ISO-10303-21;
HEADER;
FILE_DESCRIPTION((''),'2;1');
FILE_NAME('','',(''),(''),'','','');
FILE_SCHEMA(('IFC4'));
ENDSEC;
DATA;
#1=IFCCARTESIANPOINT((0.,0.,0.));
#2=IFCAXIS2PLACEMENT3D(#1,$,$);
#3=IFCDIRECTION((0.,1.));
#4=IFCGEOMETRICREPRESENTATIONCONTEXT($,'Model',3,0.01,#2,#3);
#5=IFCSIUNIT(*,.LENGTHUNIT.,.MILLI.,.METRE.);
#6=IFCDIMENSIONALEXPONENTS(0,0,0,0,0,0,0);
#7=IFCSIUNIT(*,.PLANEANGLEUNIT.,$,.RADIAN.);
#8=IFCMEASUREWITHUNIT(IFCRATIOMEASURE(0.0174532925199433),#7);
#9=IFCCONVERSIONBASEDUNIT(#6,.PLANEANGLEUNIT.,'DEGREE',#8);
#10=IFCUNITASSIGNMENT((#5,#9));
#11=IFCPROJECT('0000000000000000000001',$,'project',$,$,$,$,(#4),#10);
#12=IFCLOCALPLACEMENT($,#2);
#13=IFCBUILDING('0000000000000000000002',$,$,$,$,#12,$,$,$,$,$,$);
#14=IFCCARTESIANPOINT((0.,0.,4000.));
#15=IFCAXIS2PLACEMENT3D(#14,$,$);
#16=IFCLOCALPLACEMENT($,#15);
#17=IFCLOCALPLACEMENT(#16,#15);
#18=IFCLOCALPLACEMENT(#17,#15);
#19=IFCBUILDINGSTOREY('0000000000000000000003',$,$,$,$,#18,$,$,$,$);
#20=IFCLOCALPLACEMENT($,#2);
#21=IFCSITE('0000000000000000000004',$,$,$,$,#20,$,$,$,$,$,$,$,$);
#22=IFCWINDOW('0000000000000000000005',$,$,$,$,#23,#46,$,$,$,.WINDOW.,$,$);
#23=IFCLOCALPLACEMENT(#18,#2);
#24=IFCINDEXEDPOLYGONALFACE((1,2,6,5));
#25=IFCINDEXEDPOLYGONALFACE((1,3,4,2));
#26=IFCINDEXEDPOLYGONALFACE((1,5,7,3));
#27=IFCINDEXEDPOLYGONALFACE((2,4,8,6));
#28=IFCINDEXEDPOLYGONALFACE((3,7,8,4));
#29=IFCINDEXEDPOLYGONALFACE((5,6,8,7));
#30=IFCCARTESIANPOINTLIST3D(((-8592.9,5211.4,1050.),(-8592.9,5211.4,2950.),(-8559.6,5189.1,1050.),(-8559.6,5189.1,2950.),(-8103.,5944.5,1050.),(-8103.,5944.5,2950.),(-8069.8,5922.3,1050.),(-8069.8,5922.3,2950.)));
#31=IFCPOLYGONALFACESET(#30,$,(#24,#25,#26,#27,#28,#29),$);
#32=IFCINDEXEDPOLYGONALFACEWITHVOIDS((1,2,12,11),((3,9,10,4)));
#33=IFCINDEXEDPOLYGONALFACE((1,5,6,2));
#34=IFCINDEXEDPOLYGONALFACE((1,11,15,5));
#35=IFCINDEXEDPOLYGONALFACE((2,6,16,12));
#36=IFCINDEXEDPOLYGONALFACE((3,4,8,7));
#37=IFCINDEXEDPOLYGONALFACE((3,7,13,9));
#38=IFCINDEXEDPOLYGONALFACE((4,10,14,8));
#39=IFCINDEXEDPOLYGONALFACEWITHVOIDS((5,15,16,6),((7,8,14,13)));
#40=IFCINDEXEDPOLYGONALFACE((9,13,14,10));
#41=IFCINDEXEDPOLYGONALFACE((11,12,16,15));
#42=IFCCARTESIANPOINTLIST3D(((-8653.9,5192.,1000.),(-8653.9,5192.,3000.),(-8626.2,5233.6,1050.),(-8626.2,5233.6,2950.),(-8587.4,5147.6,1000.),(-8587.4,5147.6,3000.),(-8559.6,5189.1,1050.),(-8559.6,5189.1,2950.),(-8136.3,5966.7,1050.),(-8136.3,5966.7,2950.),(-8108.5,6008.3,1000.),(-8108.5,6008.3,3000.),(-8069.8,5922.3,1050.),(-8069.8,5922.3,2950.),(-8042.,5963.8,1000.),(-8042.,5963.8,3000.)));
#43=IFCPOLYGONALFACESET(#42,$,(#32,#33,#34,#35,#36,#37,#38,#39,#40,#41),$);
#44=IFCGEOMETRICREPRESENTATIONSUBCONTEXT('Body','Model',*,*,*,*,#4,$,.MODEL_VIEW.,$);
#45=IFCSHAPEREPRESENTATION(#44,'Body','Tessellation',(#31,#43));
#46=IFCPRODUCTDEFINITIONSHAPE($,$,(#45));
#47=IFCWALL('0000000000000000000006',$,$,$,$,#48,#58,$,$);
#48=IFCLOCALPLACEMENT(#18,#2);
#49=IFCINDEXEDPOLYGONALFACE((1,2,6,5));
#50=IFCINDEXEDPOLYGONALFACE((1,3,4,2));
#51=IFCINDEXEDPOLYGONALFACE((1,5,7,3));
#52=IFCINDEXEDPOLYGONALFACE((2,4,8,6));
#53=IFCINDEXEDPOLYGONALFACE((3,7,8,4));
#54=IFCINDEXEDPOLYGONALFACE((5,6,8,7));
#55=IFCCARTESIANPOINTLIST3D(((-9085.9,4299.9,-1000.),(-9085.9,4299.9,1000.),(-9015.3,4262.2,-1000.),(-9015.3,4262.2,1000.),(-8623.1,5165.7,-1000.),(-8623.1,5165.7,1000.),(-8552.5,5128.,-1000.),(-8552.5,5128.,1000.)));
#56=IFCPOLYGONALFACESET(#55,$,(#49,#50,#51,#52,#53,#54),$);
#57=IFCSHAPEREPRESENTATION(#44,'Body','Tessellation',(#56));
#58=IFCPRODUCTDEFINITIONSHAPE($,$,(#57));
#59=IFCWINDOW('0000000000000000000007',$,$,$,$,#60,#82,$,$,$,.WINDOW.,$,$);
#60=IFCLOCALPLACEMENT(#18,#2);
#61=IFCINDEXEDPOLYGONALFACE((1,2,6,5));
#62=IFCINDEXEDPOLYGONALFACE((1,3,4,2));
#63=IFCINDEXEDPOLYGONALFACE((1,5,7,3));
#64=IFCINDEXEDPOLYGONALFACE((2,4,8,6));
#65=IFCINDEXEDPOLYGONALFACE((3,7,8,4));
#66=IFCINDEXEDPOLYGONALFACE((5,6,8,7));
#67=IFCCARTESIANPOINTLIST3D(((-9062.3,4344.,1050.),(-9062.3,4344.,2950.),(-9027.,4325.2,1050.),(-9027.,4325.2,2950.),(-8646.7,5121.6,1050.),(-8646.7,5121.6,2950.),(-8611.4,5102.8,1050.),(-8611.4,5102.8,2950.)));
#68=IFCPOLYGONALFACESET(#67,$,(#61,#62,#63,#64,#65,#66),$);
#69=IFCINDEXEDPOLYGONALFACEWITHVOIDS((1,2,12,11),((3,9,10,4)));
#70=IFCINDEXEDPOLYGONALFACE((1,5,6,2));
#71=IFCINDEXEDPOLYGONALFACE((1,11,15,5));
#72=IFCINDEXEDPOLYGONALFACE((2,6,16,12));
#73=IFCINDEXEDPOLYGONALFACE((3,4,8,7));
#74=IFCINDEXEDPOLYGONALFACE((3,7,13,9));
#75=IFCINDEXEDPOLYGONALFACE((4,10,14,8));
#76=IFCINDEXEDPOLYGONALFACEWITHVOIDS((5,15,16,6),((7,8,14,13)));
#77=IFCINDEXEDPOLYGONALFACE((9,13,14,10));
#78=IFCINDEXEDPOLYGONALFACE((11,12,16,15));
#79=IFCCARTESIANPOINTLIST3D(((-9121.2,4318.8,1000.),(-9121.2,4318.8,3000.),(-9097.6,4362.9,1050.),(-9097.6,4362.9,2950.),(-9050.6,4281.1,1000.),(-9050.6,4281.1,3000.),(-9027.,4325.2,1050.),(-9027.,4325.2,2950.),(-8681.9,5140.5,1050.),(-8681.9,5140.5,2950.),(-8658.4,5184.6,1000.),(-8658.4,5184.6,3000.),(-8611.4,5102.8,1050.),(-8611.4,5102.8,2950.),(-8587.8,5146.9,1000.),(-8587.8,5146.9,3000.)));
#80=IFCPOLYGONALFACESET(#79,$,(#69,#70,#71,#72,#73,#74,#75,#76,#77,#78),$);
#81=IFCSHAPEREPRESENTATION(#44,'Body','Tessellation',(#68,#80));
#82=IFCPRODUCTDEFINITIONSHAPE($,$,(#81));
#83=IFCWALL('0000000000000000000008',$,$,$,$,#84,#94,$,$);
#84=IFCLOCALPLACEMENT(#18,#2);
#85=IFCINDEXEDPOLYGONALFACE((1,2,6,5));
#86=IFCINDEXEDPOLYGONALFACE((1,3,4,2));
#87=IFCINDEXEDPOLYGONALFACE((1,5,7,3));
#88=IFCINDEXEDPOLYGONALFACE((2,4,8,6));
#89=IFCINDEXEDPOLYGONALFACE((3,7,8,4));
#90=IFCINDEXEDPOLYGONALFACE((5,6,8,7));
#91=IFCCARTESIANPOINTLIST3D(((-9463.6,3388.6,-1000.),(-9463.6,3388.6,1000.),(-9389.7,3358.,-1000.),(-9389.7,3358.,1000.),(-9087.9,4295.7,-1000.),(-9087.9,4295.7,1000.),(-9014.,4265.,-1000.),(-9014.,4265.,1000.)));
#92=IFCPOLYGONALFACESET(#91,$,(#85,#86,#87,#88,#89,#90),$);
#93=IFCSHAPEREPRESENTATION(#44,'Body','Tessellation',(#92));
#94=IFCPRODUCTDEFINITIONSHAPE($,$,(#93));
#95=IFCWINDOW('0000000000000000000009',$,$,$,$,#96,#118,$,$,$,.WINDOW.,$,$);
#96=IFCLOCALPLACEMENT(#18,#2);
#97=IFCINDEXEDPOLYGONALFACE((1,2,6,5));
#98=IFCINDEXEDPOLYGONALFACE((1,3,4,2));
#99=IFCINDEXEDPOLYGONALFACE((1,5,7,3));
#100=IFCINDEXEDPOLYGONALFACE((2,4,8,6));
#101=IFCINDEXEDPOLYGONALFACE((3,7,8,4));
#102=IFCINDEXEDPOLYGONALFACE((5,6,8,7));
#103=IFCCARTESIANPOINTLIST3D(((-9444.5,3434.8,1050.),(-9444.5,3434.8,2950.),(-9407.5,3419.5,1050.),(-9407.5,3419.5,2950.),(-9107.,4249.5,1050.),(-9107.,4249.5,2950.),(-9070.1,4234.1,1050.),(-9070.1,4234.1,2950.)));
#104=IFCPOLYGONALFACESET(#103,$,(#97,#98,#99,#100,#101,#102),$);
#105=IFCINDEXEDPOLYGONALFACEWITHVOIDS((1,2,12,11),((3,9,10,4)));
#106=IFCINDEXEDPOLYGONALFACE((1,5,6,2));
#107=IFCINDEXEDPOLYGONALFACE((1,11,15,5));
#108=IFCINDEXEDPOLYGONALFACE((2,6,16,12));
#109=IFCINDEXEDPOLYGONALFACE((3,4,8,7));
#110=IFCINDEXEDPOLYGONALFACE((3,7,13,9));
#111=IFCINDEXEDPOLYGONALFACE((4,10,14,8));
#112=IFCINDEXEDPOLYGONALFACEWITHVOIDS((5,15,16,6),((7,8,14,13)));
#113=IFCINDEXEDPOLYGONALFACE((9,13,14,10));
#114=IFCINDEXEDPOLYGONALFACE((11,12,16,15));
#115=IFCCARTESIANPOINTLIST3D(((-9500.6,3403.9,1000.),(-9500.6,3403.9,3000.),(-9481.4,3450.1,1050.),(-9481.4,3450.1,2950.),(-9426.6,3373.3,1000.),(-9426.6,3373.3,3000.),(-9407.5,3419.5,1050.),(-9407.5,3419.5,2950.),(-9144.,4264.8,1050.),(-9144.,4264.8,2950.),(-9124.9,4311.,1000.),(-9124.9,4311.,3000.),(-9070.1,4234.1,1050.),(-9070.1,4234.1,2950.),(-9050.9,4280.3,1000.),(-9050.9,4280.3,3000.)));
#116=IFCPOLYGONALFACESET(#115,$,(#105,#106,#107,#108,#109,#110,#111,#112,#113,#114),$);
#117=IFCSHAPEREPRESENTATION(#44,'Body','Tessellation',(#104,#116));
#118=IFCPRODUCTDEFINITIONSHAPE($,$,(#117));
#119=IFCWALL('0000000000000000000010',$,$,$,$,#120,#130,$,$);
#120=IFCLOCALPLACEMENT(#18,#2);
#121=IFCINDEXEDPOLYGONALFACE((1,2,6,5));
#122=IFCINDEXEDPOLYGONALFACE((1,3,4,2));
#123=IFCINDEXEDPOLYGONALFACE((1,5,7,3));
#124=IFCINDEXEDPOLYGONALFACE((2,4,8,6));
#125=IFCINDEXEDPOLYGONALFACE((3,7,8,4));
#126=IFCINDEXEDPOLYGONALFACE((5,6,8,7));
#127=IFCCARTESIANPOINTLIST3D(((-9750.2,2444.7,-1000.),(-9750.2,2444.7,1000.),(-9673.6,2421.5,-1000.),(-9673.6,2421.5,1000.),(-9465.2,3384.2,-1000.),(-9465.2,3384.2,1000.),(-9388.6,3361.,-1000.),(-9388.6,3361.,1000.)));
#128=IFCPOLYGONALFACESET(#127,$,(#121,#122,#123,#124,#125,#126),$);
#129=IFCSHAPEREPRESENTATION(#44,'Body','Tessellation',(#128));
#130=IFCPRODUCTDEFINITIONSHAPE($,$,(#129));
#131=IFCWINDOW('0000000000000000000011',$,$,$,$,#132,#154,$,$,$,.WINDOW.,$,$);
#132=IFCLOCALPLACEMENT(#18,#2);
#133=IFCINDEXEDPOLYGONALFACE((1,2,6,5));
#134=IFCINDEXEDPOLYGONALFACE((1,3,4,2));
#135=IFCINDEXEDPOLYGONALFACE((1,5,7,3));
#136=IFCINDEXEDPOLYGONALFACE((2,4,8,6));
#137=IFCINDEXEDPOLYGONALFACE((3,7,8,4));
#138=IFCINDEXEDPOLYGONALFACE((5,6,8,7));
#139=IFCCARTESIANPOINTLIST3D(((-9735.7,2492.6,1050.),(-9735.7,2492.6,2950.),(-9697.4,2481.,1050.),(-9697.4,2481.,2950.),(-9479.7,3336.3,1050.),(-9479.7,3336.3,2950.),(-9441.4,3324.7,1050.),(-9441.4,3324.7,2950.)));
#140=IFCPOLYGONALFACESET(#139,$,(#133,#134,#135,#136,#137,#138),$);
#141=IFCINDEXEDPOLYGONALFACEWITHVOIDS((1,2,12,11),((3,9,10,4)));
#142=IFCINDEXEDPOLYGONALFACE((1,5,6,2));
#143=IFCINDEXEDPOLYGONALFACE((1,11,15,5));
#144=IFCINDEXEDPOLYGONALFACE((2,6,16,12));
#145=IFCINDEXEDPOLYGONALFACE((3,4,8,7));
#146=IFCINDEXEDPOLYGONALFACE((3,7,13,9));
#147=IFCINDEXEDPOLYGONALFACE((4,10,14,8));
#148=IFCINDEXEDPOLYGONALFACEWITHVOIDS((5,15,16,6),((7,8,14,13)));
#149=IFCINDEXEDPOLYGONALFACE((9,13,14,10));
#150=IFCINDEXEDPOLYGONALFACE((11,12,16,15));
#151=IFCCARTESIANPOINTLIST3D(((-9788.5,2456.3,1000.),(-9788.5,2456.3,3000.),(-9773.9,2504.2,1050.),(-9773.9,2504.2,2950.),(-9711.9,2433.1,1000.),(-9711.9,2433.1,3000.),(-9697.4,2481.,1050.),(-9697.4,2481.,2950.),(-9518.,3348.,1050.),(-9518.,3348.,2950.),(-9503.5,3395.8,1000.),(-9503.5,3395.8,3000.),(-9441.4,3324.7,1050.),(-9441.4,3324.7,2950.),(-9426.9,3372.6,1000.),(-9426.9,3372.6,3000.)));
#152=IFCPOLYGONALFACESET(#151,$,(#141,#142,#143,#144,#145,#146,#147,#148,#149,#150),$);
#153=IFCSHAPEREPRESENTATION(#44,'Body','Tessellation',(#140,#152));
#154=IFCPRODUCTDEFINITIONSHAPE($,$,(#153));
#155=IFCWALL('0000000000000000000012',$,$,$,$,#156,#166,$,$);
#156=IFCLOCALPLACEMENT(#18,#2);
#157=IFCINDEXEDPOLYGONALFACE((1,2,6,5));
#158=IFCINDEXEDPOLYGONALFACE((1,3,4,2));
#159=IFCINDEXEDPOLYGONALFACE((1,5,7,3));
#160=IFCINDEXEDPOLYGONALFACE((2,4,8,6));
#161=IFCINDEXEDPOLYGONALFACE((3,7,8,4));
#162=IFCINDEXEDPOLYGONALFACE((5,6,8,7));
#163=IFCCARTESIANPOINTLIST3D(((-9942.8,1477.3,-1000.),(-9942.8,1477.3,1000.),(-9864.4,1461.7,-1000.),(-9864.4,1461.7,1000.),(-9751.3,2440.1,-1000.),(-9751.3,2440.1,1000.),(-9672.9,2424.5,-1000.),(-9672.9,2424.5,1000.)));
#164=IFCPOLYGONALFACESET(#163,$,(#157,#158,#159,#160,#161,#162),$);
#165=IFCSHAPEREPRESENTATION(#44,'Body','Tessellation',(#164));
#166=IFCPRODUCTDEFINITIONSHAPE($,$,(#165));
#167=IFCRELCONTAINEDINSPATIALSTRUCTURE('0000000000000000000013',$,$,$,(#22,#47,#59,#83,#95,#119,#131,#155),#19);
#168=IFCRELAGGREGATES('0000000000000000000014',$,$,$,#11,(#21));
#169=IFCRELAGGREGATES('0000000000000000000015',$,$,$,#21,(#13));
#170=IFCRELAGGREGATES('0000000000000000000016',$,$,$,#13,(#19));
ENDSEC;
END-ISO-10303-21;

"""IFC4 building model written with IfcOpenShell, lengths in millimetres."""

from ifc_helpers import new_model, entity, si_unit, converted_unit, direction, frame, origin, origin_2d, place, context, subcontext, project, spatial, rectangle, extrude, element, save


model = new_model("IFC4")

# Units and contexts
model_context = context("Model", 3, precision=0.01, world=origin(), true_north=direction((0.0, 1.0)))
body_context = subcontext(model_context, "Body", "Model", "MODEL_VIEW")
ifc_project = project(units=[si_unit("LENGTHUNIT", "METRE", prefix="MILLI"), converted_unit("PLANEANGLEUNIT", "DEGREE", entity("IfcRatioMeasure", 0.0174532925199433), si_unit("PLANEANGLEUNIT", "RADIAN"), dimensions=[0, 0, 0, 0, 0, 0, 0])], contexts=[model_context])

# Site, building, storey
site_placement = place(None, origin())
site = spatial("IfcSite", under=ifc_project, at=site_placement)
building_placement = place(None, origin())
building = spatial("IfcBuilding", under=site, at=building_placement)
placement_1 = place(None, frame((0.0, 0.0, 4000.0)))
placement_2 = place(placement_1, frame((0.0, 0.0, 4000.0)))
storey_placement = place(placement_2, frame((0.0, 0.0, 4000.0)))
storey = spatial("IfcBuildingStorey", under=building, at=storey_placement)

# Shared definitions
cartesian_point_1 = entity("IfcCartesianPoint", [-440.9, -950.0])
shared_polyline = entity("IfcPolyline", [cartesian_point_1, entity("IfcCartesianPoint", [-440.9, 950.0]), entity("IfcCartesianPoint", [-440.9, 950.0]), entity("IfcCartesianPoint", [440.9, 950.0]), entity("IfcCartesianPoint", [440.9, 950.0]), entity("IfcCartesianPoint", [440.9, -950.0]), entity("IfcCartesianPoint", [440.9, -950.0]), entity("IfcCartesianPoint", [-440.9, -950.0]), cartesian_point_1])

# Window
window_1_placement = place(storey_placement, frame((-8314.7, 5555.7, 2000.0), z_axis=(0.0, 0.0, 1.0), x_axis=(-5555.701616, -8314.6966, 0.0)))
cartesian_point_2 = entity("IfcCartesianPoint", [-490.9, -1000.0])
element("IfcWindow", 1, at=window_1_placement, inside=storey, PredefinedType="WINDOW", context=body_context, shape_type="SweptSolid", body=[
    entity("IfcExtrudedAreaSolid", entity("IfcArbitraryClosedProfileDef", "AREA", None, shared_polyline), entity("IfcAxis2Placement3D", entity("IfcCartesianPoint", [0.0, 0.0, 0.0]), entity("IfcDirection", [0.0, -1.0, 0.0]), entity("IfcDirection", [1.0, 0.0, 0.0])), entity("IfcDirection", [0.0, 0.0, 1.0]), 40.0),
    entity("IfcExtrudedAreaSolid", entity("IfcArbitraryProfileDefWithVoids", "AREA", None, entity("IfcPolyline", [cartesian_point_2, entity("IfcCartesianPoint", [-490.9, 1000.0]), entity("IfcCartesianPoint", [-490.9, 1000.0]), entity("IfcCartesianPoint", [490.9, 1000.0]), entity("IfcCartesianPoint", [490.9, 1000.0]), entity("IfcCartesianPoint", [490.9, -1000.0]), entity("IfcCartesianPoint", [490.9, -1000.0]), entity("IfcCartesianPoint", [-490.9, -1000.0]), cartesian_point_2]), [shared_polyline]), entity("IfcAxis2Placement3D", entity("IfcCartesianPoint", [0.0, 0.0, 0.0]), entity("IfcDirection", [0.0, -1.0, 0.0]), entity("IfcDirection", [1.0, 0.0, 0.0])), entity("IfcDirection", [0.0, 0.0, 1.0]), 80.0),
])

# Wall
wall_1_placement = place(storey_placement, frame((-8819.2, 4714.0, -1000.0), z_axis=(0.0, 0.0, 1.0), x_axis=(-4713.96836, -8819.212113, 0.0)))
element("IfcWall", 2, at=wall_1_placement, inside=storey, context=body_context, shape_type="SweptSolid", body=[
    extrude(rectangle(XDim=981.7, YDim=80.0, at=origin_2d()), origin(), (0.0, 0.0, 1.0), 2000.0),
])

# Window
window_2_placement = place(storey_placement, frame((-8819.2, 4714.0, 2000.0), z_axis=(0.0, 0.0, 1.0), x_axis=(-4713.96836, -8819.212113, 0.0)))
cartesian_point_3 = entity("IfcCartesianPoint", [-490.9, -1000.0])
element("IfcWindow", 3, at=window_2_placement, inside=storey, PredefinedType="WINDOW", context=body_context, shape_type="SweptSolid", body=[
    entity("IfcExtrudedAreaSolid", entity("IfcArbitraryClosedProfileDef", "AREA", None, shared_polyline), entity("IfcAxis2Placement3D", entity("IfcCartesianPoint", [0.0, 0.0, 0.0]), entity("IfcDirection", [0.0, -1.0, 0.0]), entity("IfcDirection", [1.0, 0.0, 0.0])), entity("IfcDirection", [0.0, 0.0, 1.0]), 40.0),
    entity("IfcExtrudedAreaSolid", entity("IfcArbitraryProfileDefWithVoids", "AREA", None, entity("IfcPolyline", [cartesian_point_3, entity("IfcCartesianPoint", [-490.9, 1000.0]), entity("IfcCartesianPoint", [-490.9, 1000.0]), entity("IfcCartesianPoint", [490.9, 1000.0]), entity("IfcCartesianPoint", [490.9, 1000.0]), entity("IfcCartesianPoint", [490.9, -1000.0]), entity("IfcCartesianPoint", [490.9, -1000.0]), entity("IfcCartesianPoint", [-490.9, -1000.0]), cartesian_point_3]), [shared_polyline]), entity("IfcAxis2Placement3D", entity("IfcCartesianPoint", [0.0, 0.0, 0.0]), entity("IfcDirection", [0.0, -1.0, 0.0]), entity("IfcDirection", [1.0, 0.0, 0.0])), entity("IfcDirection", [0.0, 0.0, 1.0]), 80.0),
])

# Wall
wall_2_placement = place(storey_placement, frame((-9238.8, 3826.8, -1000.0), z_axis=(0.0, 0.0, 1.0), x_axis=(-3826.834994, -9238.795048, 0.0)))
element("IfcWall", 4, at=wall_2_placement, inside=storey, context=body_context, shape_type="SweptSolid", body=[
    extrude(rectangle(XDim=981.7, YDim=80.0, at=origin_2d()), origin(), (0.0, 0.0, 1.0), 2000.0),
])

# Window
window_3_placement = place(storey_placement, frame((-9238.8, 3826.8, 2000.0), z_axis=(0.0, 0.0, 1.0), x_axis=(-3826.834994, -9238.795048, 0.0)))
cartesian_point_4 = entity("IfcCartesianPoint", [-490.9, -1000.0])
element("IfcWindow", 5, at=window_3_placement, inside=storey, PredefinedType="WINDOW", context=body_context, shape_type="SweptSolid", body=[
    entity("IfcExtrudedAreaSolid", entity("IfcArbitraryClosedProfileDef", "AREA", None, shared_polyline), entity("IfcAxis2Placement3D", entity("IfcCartesianPoint", [0.0, 0.0, 0.0]), entity("IfcDirection", [0.0, -1.0, 0.0]), entity("IfcDirection", [1.0, 0.0, 0.0])), entity("IfcDirection", [0.0, 0.0, 1.0]), 40.0),
    entity("IfcExtrudedAreaSolid", entity("IfcArbitraryProfileDefWithVoids", "AREA", None, entity("IfcPolyline", [cartesian_point_4, entity("IfcCartesianPoint", [-490.9, 1000.0]), entity("IfcCartesianPoint", [-490.9, 1000.0]), entity("IfcCartesianPoint", [490.9, 1000.0]), entity("IfcCartesianPoint", [490.9, 1000.0]), entity("IfcCartesianPoint", [490.9, -1000.0]), entity("IfcCartesianPoint", [490.9, -1000.0]), entity("IfcCartesianPoint", [-490.9, -1000.0]), cartesian_point_4]), [shared_polyline]), entity("IfcAxis2Placement3D", entity("IfcCartesianPoint", [0.0, 0.0, 0.0]), entity("IfcDirection", [0.0, -1.0, 0.0]), entity("IfcDirection", [1.0, 0.0, 0.0])), entity("IfcDirection", [0.0, 0.0, 1.0]), 80.0),
])

# Wall
wall_3_placement = place(storey_placement, frame((-9569.4, 2902.8, -1000.0), z_axis=(0.0, 0.0, 1.0), x_axis=(-2902.847084, -9569.403263, 0.0)))
element("IfcWall", 6, at=wall_3_placement, inside=storey, context=body_context, shape_type="SweptSolid", body=[
    extrude(rectangle(XDim=981.7, YDim=80.0, at=origin_2d()), origin(), (0.0, 0.0, 1.0), 2000.0),
])

# Window
window_4_placement = place(storey_placement, frame((-9569.4, 2902.8, 2000.0), z_axis=(0.0, 0.0, 1.0), x_axis=(-2902.847084, -9569.403263, 0.0)))
cartesian_point_5 = entity("IfcCartesianPoint", [-490.9, -1000.0])
element("IfcWindow", 7, at=window_4_placement, inside=storey, PredefinedType="WINDOW", context=body_context, shape_type="SweptSolid", body=[
    entity("IfcExtrudedAreaSolid", entity("IfcArbitraryClosedProfileDef", "AREA", None, shared_polyline), entity("IfcAxis2Placement3D", entity("IfcCartesianPoint", [0.0, 0.0, 0.0]), entity("IfcDirection", [0.0, -1.0, 0.0]), entity("IfcDirection", [1.0, 0.0, 0.0])), entity("IfcDirection", [0.0, 0.0, 1.0]), 40.0),
    entity("IfcExtrudedAreaSolid", entity("IfcArbitraryProfileDefWithVoids", "AREA", None, entity("IfcPolyline", [cartesian_point_5, entity("IfcCartesianPoint", [-490.9, 1000.0]), entity("IfcCartesianPoint", [-490.9, 1000.0]), entity("IfcCartesianPoint", [490.9, 1000.0]), entity("IfcCartesianPoint", [490.9, 1000.0]), entity("IfcCartesianPoint", [490.9, -1000.0]), entity("IfcCartesianPoint", [490.9, -1000.0]), entity("IfcCartesianPoint", [-490.9, -1000.0]), cartesian_point_5]), [shared_polyline]), entity("IfcAxis2Placement3D", entity("IfcCartesianPoint", [0.0, 0.0, 0.0]), entity("IfcDirection", [0.0, -1.0, 0.0]), entity("IfcDirection", [1.0, 0.0, 0.0])), entity("IfcDirection", [0.0, 0.0, 1.0]), 80.0),
])

# Wall
wall_4_placement = place(storey_placement, frame((-9807.9, 1950.9, -1000.0), z_axis=(0.0, 0.0, 1.0), x_axis=(-1950.903147, -9807.852819, 0.0)))
element("IfcWall", 8, at=wall_4_placement, inside=storey, context=body_context, shape_type="SweptSolid", body=[
    extrude(rectangle(XDim=981.7, YDim=80.0, at=origin_2d()), origin(), (0.0, 0.0, 1.0), 2000.0),
])

save(model, "model.ifc")
